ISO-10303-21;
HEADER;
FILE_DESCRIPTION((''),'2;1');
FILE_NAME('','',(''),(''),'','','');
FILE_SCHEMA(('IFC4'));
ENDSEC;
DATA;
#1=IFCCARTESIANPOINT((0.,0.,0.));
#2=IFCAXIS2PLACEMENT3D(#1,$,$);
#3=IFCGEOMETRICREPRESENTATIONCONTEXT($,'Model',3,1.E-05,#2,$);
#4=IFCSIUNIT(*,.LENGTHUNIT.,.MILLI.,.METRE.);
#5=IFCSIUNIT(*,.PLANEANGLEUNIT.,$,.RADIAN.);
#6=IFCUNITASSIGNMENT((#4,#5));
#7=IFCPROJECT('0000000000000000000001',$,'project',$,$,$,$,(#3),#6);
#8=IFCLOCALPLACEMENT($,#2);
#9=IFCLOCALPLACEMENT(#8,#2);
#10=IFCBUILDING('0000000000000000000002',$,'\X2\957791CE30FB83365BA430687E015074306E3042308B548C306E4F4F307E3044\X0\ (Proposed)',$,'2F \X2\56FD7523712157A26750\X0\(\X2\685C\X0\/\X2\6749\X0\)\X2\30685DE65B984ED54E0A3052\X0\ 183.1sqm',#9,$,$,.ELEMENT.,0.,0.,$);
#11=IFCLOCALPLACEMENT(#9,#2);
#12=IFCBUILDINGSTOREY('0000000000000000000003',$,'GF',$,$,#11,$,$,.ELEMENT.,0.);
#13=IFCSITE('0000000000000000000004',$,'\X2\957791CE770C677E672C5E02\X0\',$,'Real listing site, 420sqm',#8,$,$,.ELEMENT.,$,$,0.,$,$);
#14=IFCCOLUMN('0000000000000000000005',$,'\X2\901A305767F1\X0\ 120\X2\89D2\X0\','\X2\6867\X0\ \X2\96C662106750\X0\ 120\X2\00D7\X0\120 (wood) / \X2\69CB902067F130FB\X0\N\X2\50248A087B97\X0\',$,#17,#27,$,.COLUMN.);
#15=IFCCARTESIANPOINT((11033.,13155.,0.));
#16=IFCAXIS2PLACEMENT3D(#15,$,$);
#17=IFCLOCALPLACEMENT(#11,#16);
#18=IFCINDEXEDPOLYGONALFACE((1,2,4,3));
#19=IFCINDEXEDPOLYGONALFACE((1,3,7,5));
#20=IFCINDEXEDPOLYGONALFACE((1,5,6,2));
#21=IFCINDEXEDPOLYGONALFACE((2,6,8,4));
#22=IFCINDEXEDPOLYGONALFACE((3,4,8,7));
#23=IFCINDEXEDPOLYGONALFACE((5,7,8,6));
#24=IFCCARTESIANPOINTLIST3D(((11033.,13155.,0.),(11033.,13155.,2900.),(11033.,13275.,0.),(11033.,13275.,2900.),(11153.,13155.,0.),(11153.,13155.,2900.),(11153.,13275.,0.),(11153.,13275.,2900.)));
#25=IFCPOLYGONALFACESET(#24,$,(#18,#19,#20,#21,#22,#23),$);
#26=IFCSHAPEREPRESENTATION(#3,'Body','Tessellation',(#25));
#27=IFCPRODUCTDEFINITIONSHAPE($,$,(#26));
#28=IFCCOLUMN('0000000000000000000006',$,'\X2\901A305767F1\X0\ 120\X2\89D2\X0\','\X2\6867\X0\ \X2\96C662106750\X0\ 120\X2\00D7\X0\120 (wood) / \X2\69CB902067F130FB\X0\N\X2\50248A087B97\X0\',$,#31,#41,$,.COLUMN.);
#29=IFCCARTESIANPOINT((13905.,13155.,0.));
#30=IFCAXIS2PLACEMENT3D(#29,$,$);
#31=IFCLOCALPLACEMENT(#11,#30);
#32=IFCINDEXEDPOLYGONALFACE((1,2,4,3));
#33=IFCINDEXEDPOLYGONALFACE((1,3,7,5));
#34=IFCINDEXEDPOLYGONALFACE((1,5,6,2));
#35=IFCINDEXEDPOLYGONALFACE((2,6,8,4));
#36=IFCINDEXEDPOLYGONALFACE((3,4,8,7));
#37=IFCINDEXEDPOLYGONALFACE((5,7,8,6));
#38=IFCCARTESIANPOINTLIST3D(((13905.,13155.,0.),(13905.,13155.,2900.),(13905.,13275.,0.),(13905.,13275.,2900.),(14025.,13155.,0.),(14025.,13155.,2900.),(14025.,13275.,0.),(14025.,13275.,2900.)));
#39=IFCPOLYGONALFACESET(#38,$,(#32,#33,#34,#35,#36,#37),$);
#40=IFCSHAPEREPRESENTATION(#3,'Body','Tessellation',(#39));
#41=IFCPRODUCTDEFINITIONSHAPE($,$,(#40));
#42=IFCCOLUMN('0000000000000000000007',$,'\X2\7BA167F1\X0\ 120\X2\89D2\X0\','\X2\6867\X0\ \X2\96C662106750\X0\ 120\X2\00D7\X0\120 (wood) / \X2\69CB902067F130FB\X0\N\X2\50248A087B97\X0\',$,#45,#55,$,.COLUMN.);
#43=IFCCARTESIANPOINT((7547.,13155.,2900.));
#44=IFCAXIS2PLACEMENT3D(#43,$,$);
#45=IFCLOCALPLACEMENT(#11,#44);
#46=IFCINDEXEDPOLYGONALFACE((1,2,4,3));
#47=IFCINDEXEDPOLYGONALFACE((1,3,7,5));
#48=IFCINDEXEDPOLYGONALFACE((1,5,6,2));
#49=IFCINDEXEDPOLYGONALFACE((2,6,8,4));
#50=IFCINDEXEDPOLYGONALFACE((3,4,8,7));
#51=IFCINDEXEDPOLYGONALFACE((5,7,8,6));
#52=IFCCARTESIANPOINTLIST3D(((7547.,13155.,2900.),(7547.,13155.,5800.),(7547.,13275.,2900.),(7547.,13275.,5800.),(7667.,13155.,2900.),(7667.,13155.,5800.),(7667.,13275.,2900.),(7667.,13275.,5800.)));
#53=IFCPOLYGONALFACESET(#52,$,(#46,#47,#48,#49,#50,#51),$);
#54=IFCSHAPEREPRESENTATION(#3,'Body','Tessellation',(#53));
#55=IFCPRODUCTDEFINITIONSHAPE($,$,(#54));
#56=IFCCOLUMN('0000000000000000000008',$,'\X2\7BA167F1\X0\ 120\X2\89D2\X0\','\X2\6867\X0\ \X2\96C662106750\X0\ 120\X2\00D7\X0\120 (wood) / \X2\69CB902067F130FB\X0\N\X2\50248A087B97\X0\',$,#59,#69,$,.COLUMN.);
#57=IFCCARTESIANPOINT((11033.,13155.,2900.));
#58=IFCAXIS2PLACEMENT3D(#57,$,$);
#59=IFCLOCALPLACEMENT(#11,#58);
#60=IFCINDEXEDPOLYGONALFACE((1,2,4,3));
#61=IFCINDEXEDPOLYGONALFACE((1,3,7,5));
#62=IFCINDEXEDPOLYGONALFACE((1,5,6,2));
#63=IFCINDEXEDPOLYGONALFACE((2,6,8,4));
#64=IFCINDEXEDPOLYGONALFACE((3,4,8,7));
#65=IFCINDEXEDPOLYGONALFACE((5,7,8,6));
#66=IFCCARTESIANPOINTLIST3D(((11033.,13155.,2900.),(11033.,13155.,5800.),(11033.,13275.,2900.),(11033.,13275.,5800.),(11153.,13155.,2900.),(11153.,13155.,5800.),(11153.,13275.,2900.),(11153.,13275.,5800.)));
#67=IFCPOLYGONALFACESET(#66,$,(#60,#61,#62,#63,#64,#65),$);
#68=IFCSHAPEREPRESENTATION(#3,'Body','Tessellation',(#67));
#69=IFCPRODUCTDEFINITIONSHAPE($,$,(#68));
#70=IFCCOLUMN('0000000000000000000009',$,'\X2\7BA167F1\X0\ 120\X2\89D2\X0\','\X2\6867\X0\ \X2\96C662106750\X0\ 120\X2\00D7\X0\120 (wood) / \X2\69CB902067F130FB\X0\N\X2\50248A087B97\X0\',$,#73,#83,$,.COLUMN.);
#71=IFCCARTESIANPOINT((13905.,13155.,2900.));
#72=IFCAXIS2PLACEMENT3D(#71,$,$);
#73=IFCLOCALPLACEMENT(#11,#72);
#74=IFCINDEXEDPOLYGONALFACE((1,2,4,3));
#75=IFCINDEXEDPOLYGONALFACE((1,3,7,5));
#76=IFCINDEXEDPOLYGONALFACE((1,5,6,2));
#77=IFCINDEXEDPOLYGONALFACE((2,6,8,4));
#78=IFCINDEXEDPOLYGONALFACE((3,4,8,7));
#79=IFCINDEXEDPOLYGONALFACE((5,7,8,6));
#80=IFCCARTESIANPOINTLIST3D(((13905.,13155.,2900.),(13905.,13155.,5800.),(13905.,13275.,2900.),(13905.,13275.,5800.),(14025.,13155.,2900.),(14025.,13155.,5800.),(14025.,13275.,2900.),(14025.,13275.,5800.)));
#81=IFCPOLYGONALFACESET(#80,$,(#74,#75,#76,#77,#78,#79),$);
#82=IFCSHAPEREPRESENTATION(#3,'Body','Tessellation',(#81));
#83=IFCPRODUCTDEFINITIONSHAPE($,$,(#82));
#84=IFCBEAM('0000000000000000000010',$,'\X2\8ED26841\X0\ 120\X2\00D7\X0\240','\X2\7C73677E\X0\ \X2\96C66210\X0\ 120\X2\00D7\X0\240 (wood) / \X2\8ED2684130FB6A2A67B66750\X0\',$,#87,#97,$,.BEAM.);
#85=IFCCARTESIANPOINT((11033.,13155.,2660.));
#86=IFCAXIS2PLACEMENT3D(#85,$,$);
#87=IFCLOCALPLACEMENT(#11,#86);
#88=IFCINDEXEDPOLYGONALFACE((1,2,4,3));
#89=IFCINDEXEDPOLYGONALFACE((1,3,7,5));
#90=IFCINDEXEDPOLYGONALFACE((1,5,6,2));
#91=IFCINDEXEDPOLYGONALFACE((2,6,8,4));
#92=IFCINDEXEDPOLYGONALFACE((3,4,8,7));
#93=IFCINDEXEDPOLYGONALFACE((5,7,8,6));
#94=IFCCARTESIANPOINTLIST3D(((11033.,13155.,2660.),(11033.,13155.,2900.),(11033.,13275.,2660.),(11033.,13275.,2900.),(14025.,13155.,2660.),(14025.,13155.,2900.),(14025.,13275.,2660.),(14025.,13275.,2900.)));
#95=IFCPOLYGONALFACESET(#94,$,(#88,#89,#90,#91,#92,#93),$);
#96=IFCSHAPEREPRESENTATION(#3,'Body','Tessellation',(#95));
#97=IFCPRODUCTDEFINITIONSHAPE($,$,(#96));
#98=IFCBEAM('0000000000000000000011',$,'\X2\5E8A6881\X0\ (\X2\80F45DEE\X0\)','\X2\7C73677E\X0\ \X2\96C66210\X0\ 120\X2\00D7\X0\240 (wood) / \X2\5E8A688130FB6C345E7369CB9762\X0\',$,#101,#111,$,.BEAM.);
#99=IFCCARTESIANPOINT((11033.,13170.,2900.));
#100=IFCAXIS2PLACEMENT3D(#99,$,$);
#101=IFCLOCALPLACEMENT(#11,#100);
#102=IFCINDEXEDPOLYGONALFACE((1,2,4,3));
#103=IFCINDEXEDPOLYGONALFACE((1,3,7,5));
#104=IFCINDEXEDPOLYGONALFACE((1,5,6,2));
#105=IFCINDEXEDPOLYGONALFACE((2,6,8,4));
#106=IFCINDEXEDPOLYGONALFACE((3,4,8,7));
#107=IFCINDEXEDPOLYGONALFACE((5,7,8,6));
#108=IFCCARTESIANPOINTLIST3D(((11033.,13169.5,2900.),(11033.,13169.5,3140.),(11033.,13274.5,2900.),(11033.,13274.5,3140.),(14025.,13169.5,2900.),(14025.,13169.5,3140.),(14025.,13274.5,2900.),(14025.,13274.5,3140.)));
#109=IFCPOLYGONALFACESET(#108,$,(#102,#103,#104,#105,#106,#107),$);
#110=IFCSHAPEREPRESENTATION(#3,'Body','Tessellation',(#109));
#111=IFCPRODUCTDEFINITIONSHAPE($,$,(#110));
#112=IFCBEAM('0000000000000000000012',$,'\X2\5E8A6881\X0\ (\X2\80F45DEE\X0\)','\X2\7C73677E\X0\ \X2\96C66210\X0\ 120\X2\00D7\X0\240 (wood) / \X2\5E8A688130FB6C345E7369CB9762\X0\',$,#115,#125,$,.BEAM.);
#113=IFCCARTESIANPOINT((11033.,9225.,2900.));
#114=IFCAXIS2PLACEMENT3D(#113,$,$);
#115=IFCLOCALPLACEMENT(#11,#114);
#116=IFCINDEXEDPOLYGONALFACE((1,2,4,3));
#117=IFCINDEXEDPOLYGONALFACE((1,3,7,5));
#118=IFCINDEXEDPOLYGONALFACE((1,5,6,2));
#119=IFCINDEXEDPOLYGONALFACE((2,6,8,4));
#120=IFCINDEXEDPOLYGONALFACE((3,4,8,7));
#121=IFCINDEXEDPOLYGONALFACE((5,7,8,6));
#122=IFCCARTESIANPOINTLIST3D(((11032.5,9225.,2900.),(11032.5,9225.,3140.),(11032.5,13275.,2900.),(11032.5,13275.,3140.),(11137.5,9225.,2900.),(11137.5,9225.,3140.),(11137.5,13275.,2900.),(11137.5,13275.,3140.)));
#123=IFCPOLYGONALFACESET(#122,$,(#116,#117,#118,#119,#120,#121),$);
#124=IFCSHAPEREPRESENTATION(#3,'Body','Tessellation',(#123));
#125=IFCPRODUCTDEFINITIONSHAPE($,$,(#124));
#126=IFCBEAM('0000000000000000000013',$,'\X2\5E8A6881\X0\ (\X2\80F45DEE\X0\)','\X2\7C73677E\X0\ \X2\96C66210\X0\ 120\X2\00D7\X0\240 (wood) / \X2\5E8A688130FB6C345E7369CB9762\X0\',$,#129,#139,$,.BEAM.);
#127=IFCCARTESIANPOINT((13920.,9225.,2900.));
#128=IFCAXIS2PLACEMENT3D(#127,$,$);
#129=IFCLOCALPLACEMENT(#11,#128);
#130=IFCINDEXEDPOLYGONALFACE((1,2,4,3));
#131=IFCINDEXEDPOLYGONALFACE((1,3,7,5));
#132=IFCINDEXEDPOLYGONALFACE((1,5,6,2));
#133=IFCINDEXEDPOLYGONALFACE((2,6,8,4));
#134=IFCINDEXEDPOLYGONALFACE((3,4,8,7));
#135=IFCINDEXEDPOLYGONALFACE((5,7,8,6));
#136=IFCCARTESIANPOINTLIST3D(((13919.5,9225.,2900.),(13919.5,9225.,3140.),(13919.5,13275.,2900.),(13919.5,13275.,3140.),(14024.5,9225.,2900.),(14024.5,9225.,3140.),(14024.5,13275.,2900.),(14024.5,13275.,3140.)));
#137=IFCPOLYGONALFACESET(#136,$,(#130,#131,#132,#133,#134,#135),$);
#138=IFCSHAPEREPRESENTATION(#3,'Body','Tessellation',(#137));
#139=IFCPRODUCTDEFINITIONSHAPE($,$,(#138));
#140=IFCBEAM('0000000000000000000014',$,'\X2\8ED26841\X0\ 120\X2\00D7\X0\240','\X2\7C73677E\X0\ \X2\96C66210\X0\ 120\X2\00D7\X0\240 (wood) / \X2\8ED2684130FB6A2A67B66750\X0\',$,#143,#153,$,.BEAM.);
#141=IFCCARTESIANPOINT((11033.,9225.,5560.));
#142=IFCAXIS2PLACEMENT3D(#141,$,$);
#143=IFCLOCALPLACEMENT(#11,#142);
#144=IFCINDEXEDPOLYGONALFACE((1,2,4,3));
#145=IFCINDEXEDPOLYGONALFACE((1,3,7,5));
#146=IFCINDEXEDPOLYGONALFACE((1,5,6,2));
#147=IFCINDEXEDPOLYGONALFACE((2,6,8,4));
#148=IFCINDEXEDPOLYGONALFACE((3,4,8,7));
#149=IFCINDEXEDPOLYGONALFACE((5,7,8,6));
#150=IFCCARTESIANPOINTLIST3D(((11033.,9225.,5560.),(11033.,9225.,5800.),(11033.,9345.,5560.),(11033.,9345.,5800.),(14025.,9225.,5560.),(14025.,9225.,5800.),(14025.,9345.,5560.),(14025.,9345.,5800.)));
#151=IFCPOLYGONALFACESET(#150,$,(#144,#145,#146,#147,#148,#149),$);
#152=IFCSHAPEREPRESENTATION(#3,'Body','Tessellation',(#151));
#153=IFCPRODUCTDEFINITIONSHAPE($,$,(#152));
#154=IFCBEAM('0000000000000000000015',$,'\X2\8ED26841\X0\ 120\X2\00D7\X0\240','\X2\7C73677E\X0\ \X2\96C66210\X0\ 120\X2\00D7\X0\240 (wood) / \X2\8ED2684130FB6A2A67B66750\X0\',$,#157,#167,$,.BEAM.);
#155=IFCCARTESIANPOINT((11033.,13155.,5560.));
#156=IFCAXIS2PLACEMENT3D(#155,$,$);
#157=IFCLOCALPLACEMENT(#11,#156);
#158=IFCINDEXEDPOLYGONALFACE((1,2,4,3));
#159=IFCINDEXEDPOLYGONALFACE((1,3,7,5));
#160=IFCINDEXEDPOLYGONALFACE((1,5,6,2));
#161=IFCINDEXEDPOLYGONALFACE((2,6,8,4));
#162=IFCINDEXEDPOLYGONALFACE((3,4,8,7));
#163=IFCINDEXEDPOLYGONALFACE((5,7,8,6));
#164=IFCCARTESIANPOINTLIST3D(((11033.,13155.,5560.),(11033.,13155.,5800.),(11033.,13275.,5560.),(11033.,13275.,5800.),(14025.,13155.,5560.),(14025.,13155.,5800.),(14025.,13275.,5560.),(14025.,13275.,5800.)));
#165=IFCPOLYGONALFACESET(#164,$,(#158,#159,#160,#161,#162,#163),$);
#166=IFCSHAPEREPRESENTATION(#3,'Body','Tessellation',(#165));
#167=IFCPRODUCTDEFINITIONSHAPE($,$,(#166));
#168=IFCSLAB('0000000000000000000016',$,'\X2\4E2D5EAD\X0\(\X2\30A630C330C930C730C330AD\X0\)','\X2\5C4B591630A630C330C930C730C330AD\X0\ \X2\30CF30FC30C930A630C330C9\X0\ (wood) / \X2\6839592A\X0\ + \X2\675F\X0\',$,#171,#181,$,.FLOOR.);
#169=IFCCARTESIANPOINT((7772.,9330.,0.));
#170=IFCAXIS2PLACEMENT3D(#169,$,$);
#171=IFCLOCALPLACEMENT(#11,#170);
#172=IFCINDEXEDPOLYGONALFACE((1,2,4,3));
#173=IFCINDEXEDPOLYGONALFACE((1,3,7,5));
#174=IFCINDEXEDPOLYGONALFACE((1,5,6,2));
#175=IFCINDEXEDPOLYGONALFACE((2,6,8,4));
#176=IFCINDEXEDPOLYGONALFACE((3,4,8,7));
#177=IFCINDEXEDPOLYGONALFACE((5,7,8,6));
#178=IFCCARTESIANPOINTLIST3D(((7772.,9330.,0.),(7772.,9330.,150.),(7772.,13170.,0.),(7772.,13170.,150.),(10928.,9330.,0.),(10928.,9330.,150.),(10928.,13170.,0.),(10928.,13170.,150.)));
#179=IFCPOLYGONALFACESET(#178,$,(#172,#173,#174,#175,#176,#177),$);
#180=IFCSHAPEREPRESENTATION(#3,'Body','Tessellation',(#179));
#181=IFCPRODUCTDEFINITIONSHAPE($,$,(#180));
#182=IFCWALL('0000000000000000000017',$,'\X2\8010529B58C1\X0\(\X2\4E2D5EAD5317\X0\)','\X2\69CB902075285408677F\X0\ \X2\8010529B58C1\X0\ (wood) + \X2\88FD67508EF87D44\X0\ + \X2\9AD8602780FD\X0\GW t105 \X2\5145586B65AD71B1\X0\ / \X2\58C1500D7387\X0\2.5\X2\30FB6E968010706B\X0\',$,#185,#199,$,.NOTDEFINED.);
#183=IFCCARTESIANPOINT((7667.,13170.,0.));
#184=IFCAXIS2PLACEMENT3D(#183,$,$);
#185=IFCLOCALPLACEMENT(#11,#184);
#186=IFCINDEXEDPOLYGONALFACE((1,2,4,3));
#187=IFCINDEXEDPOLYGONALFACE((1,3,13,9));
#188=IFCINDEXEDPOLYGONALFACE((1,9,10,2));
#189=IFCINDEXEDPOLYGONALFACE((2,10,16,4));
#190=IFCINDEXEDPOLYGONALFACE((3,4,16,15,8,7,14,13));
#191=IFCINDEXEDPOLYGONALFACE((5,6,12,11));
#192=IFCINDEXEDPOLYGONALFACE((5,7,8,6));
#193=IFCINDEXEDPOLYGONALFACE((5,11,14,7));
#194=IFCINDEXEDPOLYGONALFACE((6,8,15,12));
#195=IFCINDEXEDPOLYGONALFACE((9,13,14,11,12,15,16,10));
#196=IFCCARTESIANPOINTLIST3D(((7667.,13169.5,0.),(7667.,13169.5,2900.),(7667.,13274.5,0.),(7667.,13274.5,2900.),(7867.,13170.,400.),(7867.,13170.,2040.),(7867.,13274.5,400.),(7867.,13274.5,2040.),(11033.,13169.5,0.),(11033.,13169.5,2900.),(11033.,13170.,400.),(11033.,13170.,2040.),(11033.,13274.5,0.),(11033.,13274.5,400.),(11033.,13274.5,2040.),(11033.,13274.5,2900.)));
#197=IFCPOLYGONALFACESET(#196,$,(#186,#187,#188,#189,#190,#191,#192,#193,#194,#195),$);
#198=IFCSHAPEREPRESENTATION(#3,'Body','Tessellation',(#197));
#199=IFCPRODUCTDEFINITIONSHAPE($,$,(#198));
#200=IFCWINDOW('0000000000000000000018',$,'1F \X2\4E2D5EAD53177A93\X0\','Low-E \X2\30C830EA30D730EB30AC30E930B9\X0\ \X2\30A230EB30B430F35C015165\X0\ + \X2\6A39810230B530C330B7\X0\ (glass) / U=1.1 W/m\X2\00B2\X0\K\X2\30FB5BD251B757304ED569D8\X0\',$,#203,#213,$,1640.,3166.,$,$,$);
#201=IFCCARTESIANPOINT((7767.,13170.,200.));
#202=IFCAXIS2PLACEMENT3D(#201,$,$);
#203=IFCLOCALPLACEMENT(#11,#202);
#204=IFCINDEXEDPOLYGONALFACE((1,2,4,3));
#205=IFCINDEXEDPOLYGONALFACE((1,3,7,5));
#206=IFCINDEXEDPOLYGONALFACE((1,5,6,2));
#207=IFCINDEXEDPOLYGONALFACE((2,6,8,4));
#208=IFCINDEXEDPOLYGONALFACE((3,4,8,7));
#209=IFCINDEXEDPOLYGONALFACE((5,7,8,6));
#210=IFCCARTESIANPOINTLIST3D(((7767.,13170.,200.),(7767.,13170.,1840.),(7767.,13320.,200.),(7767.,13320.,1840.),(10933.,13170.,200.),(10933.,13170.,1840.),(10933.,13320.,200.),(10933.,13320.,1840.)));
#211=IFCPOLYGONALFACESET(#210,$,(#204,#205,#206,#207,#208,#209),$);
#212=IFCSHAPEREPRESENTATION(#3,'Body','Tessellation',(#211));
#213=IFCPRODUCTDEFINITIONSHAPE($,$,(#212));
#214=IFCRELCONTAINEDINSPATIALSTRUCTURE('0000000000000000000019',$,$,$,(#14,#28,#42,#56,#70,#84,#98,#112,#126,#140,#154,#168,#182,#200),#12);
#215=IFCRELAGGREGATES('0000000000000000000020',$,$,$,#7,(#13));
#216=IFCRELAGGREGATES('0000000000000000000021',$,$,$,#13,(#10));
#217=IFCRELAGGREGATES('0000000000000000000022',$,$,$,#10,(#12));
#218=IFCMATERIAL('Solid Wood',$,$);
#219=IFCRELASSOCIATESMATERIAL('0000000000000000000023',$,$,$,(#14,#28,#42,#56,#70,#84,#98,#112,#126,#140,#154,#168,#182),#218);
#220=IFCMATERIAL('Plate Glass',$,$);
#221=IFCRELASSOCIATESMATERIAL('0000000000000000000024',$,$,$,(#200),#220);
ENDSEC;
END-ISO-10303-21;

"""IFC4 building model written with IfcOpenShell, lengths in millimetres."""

from ifc_helpers import new_model, si_unit, frame, frame_2d, origin, place, context, project, spatial, rectangle, extrude, material, element, fill, save


model = new_model("IFC4")

# Units and contexts
model_context = context("Model", 3, precision=1e-05, world=origin())
ifc_project = project(units=[si_unit("LENGTHUNIT", "METRE", prefix="MILLI"), si_unit("PLANEANGLEUNIT", "RADIAN")], contexts=[model_context])

# Site, building, storey
site_placement = place(None, origin())
site = spatial("IfcSite", under=ifc_project, at=site_placement, Name="長野県松本市", ObjectType="Real listing site, 420sqm", CompositionType="ELEMENT", RefElevation=0.0)
building_placement = place(site_placement, origin())
building = spatial("IfcBuilding", under=site, at=building_placement, Name="長野・茶室と縁側のある和の住まい (Proposed)", ObjectType="2F 国産無垢材(桜/杉)と左官仕上げ 183.1sqm", CompositionType="ELEMENT", ElevationOfRefHeight=0.0, ElevationOfTerrain=0.0)
storey_placement = place(building_placement, origin())
storey = spatial("IfcBuildingStorey", under=building, at=storey_placement, Name="GF", CompositionType="ELEMENT", Elevation=0.0)

# Columns
ifc_material_1 = material(Name="Solid Wood")
column_1_placement = place(storey_placement, frame((11033.0, 13155.0, 0.0)))
element("IfcColumn", 1, at=column_1_placement, inside=storey, material=ifc_material_1, Name="通し柱 120角", Description="桧 集成材 120×120 (wood) / 構造柱・N値計算", PredefinedType="COLUMN", context=model_context, shape_type="SweptSolid", body=[
    extrude(rectangle(XDim=120.0, YDim=120.0, at=frame_2d((60.0, 60.0))), frame((11033.0, 13155.0, 0.0)), (0.0, 0.0, 1.0), 2900.0),
])
column_2_placement = place(storey_placement, frame((13905.0, 13155.0, 0.0)))
element("IfcColumn", 2, at=column_2_placement, inside=storey, material=ifc_material_1, Name="通し柱 120角", Description="桧 集成材 120×120 (wood) / 構造柱・N値計算", PredefinedType="COLUMN", context=model_context, shape_type="SweptSolid", body=[
    extrude(rectangle(XDim=120.0, YDim=120.0, at=frame_2d((60.0, 60.0))), frame((13905.0, 13155.0, 0.0)), (0.0, 0.0, 1.0), 2900.0),
])
column_3_placement = place(storey_placement, frame((7547.0, 13155.0, 2900.0)))
element("IfcColumn", 3, at=column_3_placement, inside=storey, material=ifc_material_1, Name="管柱 120角", Description="桧 集成材 120×120 (wood) / 構造柱・N値計算", PredefinedType="COLUMN", context=model_context, shape_type="SweptSolid", body=[
    extrude(rectangle(XDim=120.0, YDim=120.0, at=frame_2d((60.0, 60.0))), frame((7547.0, 13155.0, 2900.0)), (0.0, 0.0, 1.0), 2900.0),
])
column_4_placement = place(storey_placement, frame((11033.0, 13155.0, 2900.0)))
element("IfcColumn", 4, at=column_4_placement, inside=storey, material=ifc_material_1, Name="管柱 120角", Description="桧 集成材 120×120 (wood) / 構造柱・N値計算", PredefinedType="COLUMN", context=model_context, shape_type="SweptSolid", body=[
    extrude(rectangle(XDim=120.0, YDim=120.0, at=frame_2d((60.0, 60.0))), frame((11033.0, 13155.0, 2900.0)), (0.0, 0.0, 1.0), 2900.0),
])
column_5_placement = place(storey_placement, frame((13905.0, 13155.0, 2900.0)))
element("IfcColumn", 5, at=column_5_placement, inside=storey, material=ifc_material_1, Name="管柱 120角", Description="桧 集成材 120×120 (wood) / 構造柱・N値計算", PredefinedType="COLUMN", context=model_context, shape_type="SweptSolid", body=[
    extrude(rectangle(XDim=120.0, YDim=120.0, at=frame_2d((60.0, 60.0))), frame((13905.0, 13155.0, 2900.0)), (0.0, 0.0, 1.0), 2900.0),
])

# Beams
beam_1_placement = place(storey_placement, frame((11033.0, 13155.0, 2660.0)))
element("IfcBeam", 6, at=beam_1_placement, inside=storey, material=ifc_material_1, Name="軒桁 120×240", Description="米松 集成 120×240 (wood) / 軒桁・横架材", PredefinedType="BEAM", context=model_context, shape_type="SweptSolid", body=[
    extrude(rectangle(XDim=2992.0, YDim=120.0, at=frame_2d((1496.0, 60.0))), frame((11033.0, 13155.0, 2660.0)), (0.0, 0.0, 1.0), 240.0),
])
beam_2_placement = place(storey_placement, frame((11033.0, 13170.0, 2900.0)))
element("IfcBeam", 7, at=beam_2_placement, inside=storey, material=ifc_material_1, Name="床梁 (胴差)", Description="米松 集成 120×240 (wood) / 床梁・水平構面", PredefinedType="BEAM", context=model_context, shape_type="SweptSolid", body=[
    extrude(rectangle(XDim=2992.0, YDim=105.0, at=frame_2d((1496.0, 52.0))), frame((11033.0, 13170.0, 2900.0)), (0.0, 0.0, 1.0), 240.0),
])
beam_3_placement = place(storey_placement, frame((11033.0, 9225.0, 2900.0)))
element("IfcBeam", 8, at=beam_3_placement, inside=storey, material=ifc_material_1, Name="床梁 (胴差)", Description="米松 集成 120×240 (wood) / 床梁・水平構面", PredefinedType="BEAM", context=model_context, shape_type="SweptSolid", body=[
    extrude(rectangle(XDim=105.0, YDim=4050.0, at=frame_2d((52.0, 2025.0))), frame((11033.0, 9225.0, 2900.0)), (0.0, 0.0, 1.0), 240.0),
])
beam_4_placement = place(storey_placement, frame((13920.0, 9225.0, 2900.0)))
element("IfcBeam", 9, at=beam_4_placement, inside=storey, material=ifc_material_1, Name="床梁 (胴差)", Description="米松 集成 120×240 (wood) / 床梁・水平構面", PredefinedType="BEAM", context=model_context, shape_type="SweptSolid", body=[
    extrude(rectangle(XDim=105.0, YDim=4050.0, at=frame_2d((52.0, 2025.0))), frame((13920.0, 9225.0, 2900.0)), (0.0, 0.0, 1.0), 240.0),
])
beam_5_placement = place(storey_placement, frame((11033.0, 9225.0, 5560.0)))
element("IfcBeam", 10, at=beam_5_placement, inside=storey, material=ifc_material_1, Name="軒桁 120×240", Description="米松 集成 120×240 (wood) / 軒桁・横架材", PredefinedType="BEAM", context=model_context, shape_type="SweptSolid", body=[
    extrude(rectangle(XDim=2992.0, YDim=120.0, at=frame_2d((1496.0, 60.0))), frame((11033.0, 9225.0, 5560.0)), (0.0, 0.0, 1.0), 240.0),
])
beam_6_placement = place(storey_placement, frame((11033.0, 13155.0, 5560.0)))
element("IfcBeam", 11, at=beam_6_placement, inside=storey, material=ifc_material_1, Name="軒桁 120×240", Description="米松 集成 120×240 (wood) / 軒桁・横架材", PredefinedType="BEAM", context=model_context, shape_type="SweptSolid", body=[
    extrude(rectangle(XDim=2992.0, YDim=120.0, at=frame_2d((1496.0, 60.0))), frame((11033.0, 13155.0, 5560.0)), (0.0, 0.0, 1.0), 240.0),
])

# Slab
slab_placement = place(storey_placement, frame((7772.0, 9330.0, 0.0)))
element("IfcSlab", 12, at=slab_placement, inside=storey, material=ifc_material_1, Name="中庭(ウッドデッキ)", Description="屋外ウッドデッキ ハードウッド (wood) / 根太 + 束", PredefinedType="FLOOR", context=model_context, shape_type="SweptSolid", body=[
    extrude(rectangle(XDim=3156.0, YDim=3840.0, at=frame_2d((1578.0, 1920.0))), frame((7772.0, 9330.0, 0.0)), (0.0, 0.0, 1.0), 150.0),
])

# Wall, opening, window
wall_1_placement = place(storey_placement, frame((7667.0, 13170.0, 0.0)))
wall_1 = element("IfcWall", 13, at=wall_1_placement, inside=storey, material=ifc_material_1, Name="耐力壁(中庭北)", Description="構造用合板 耐力壁 (wood) + 製材軸組 + 高性能GW t105 充填断熱 / 壁倍率2.5・準耐火", PredefinedType="NOTDEFINED", context=model_context, shape_type="SweptSolid", body=[
    extrude(rectangle(XDim=3366.0, YDim=105.0, at=frame_2d((1683.0, 52.0))), frame((7667.0, 13170.0, 0.0)), (0.0, 0.0, 1.0), 2900.0),
])
opening_1_placement = place(storey_placement, frame((7767.0, 13170.0, 200.0)))
opening_1 = element("IfcOpeningElement", 14, at=opening_1_placement, cuts=wall_1, PredefinedType="NOTDEFINED", context=model_context, shape_type="SweptSolid", body=[
    extrude(rectangle(XDim=3166.0, YDim=150.0, at=frame_2d((1583.0, 75.0))), frame((7767.0, 13170.0, 200.0)), (0.0, 0.0, 1.0), 1640.0),
])
ifc_material_2 = material(Name="Plate Glass")
window_1_placement = place(storey_placement, frame((7767.0, 13170.0, 200.0)))
window_1 = element("IfcWindow", 15, at=window_1_placement, inside=storey, material=ifc_material_2, Name="1F 中庭北窓", Description="Low-E トリプルガラス アルゴン封入 + 樹脂サッシ (glass) / U=1.1 W/m²K・寒冷地仕様", OverallHeight=1640.0, OverallWidth=3166.0, context=model_context, shape_type="SweptSolid", body=[
    extrude(rectangle(XDim=3166.0, YDim=150.0, at=frame_2d((1583.0, 75.0))), frame((7767.0, 13170.0, 200.0)), (0.0, 0.0, 1.0), 1640.0),
])
fill(opening_1, window_1)

save(model, "model.ifc")
